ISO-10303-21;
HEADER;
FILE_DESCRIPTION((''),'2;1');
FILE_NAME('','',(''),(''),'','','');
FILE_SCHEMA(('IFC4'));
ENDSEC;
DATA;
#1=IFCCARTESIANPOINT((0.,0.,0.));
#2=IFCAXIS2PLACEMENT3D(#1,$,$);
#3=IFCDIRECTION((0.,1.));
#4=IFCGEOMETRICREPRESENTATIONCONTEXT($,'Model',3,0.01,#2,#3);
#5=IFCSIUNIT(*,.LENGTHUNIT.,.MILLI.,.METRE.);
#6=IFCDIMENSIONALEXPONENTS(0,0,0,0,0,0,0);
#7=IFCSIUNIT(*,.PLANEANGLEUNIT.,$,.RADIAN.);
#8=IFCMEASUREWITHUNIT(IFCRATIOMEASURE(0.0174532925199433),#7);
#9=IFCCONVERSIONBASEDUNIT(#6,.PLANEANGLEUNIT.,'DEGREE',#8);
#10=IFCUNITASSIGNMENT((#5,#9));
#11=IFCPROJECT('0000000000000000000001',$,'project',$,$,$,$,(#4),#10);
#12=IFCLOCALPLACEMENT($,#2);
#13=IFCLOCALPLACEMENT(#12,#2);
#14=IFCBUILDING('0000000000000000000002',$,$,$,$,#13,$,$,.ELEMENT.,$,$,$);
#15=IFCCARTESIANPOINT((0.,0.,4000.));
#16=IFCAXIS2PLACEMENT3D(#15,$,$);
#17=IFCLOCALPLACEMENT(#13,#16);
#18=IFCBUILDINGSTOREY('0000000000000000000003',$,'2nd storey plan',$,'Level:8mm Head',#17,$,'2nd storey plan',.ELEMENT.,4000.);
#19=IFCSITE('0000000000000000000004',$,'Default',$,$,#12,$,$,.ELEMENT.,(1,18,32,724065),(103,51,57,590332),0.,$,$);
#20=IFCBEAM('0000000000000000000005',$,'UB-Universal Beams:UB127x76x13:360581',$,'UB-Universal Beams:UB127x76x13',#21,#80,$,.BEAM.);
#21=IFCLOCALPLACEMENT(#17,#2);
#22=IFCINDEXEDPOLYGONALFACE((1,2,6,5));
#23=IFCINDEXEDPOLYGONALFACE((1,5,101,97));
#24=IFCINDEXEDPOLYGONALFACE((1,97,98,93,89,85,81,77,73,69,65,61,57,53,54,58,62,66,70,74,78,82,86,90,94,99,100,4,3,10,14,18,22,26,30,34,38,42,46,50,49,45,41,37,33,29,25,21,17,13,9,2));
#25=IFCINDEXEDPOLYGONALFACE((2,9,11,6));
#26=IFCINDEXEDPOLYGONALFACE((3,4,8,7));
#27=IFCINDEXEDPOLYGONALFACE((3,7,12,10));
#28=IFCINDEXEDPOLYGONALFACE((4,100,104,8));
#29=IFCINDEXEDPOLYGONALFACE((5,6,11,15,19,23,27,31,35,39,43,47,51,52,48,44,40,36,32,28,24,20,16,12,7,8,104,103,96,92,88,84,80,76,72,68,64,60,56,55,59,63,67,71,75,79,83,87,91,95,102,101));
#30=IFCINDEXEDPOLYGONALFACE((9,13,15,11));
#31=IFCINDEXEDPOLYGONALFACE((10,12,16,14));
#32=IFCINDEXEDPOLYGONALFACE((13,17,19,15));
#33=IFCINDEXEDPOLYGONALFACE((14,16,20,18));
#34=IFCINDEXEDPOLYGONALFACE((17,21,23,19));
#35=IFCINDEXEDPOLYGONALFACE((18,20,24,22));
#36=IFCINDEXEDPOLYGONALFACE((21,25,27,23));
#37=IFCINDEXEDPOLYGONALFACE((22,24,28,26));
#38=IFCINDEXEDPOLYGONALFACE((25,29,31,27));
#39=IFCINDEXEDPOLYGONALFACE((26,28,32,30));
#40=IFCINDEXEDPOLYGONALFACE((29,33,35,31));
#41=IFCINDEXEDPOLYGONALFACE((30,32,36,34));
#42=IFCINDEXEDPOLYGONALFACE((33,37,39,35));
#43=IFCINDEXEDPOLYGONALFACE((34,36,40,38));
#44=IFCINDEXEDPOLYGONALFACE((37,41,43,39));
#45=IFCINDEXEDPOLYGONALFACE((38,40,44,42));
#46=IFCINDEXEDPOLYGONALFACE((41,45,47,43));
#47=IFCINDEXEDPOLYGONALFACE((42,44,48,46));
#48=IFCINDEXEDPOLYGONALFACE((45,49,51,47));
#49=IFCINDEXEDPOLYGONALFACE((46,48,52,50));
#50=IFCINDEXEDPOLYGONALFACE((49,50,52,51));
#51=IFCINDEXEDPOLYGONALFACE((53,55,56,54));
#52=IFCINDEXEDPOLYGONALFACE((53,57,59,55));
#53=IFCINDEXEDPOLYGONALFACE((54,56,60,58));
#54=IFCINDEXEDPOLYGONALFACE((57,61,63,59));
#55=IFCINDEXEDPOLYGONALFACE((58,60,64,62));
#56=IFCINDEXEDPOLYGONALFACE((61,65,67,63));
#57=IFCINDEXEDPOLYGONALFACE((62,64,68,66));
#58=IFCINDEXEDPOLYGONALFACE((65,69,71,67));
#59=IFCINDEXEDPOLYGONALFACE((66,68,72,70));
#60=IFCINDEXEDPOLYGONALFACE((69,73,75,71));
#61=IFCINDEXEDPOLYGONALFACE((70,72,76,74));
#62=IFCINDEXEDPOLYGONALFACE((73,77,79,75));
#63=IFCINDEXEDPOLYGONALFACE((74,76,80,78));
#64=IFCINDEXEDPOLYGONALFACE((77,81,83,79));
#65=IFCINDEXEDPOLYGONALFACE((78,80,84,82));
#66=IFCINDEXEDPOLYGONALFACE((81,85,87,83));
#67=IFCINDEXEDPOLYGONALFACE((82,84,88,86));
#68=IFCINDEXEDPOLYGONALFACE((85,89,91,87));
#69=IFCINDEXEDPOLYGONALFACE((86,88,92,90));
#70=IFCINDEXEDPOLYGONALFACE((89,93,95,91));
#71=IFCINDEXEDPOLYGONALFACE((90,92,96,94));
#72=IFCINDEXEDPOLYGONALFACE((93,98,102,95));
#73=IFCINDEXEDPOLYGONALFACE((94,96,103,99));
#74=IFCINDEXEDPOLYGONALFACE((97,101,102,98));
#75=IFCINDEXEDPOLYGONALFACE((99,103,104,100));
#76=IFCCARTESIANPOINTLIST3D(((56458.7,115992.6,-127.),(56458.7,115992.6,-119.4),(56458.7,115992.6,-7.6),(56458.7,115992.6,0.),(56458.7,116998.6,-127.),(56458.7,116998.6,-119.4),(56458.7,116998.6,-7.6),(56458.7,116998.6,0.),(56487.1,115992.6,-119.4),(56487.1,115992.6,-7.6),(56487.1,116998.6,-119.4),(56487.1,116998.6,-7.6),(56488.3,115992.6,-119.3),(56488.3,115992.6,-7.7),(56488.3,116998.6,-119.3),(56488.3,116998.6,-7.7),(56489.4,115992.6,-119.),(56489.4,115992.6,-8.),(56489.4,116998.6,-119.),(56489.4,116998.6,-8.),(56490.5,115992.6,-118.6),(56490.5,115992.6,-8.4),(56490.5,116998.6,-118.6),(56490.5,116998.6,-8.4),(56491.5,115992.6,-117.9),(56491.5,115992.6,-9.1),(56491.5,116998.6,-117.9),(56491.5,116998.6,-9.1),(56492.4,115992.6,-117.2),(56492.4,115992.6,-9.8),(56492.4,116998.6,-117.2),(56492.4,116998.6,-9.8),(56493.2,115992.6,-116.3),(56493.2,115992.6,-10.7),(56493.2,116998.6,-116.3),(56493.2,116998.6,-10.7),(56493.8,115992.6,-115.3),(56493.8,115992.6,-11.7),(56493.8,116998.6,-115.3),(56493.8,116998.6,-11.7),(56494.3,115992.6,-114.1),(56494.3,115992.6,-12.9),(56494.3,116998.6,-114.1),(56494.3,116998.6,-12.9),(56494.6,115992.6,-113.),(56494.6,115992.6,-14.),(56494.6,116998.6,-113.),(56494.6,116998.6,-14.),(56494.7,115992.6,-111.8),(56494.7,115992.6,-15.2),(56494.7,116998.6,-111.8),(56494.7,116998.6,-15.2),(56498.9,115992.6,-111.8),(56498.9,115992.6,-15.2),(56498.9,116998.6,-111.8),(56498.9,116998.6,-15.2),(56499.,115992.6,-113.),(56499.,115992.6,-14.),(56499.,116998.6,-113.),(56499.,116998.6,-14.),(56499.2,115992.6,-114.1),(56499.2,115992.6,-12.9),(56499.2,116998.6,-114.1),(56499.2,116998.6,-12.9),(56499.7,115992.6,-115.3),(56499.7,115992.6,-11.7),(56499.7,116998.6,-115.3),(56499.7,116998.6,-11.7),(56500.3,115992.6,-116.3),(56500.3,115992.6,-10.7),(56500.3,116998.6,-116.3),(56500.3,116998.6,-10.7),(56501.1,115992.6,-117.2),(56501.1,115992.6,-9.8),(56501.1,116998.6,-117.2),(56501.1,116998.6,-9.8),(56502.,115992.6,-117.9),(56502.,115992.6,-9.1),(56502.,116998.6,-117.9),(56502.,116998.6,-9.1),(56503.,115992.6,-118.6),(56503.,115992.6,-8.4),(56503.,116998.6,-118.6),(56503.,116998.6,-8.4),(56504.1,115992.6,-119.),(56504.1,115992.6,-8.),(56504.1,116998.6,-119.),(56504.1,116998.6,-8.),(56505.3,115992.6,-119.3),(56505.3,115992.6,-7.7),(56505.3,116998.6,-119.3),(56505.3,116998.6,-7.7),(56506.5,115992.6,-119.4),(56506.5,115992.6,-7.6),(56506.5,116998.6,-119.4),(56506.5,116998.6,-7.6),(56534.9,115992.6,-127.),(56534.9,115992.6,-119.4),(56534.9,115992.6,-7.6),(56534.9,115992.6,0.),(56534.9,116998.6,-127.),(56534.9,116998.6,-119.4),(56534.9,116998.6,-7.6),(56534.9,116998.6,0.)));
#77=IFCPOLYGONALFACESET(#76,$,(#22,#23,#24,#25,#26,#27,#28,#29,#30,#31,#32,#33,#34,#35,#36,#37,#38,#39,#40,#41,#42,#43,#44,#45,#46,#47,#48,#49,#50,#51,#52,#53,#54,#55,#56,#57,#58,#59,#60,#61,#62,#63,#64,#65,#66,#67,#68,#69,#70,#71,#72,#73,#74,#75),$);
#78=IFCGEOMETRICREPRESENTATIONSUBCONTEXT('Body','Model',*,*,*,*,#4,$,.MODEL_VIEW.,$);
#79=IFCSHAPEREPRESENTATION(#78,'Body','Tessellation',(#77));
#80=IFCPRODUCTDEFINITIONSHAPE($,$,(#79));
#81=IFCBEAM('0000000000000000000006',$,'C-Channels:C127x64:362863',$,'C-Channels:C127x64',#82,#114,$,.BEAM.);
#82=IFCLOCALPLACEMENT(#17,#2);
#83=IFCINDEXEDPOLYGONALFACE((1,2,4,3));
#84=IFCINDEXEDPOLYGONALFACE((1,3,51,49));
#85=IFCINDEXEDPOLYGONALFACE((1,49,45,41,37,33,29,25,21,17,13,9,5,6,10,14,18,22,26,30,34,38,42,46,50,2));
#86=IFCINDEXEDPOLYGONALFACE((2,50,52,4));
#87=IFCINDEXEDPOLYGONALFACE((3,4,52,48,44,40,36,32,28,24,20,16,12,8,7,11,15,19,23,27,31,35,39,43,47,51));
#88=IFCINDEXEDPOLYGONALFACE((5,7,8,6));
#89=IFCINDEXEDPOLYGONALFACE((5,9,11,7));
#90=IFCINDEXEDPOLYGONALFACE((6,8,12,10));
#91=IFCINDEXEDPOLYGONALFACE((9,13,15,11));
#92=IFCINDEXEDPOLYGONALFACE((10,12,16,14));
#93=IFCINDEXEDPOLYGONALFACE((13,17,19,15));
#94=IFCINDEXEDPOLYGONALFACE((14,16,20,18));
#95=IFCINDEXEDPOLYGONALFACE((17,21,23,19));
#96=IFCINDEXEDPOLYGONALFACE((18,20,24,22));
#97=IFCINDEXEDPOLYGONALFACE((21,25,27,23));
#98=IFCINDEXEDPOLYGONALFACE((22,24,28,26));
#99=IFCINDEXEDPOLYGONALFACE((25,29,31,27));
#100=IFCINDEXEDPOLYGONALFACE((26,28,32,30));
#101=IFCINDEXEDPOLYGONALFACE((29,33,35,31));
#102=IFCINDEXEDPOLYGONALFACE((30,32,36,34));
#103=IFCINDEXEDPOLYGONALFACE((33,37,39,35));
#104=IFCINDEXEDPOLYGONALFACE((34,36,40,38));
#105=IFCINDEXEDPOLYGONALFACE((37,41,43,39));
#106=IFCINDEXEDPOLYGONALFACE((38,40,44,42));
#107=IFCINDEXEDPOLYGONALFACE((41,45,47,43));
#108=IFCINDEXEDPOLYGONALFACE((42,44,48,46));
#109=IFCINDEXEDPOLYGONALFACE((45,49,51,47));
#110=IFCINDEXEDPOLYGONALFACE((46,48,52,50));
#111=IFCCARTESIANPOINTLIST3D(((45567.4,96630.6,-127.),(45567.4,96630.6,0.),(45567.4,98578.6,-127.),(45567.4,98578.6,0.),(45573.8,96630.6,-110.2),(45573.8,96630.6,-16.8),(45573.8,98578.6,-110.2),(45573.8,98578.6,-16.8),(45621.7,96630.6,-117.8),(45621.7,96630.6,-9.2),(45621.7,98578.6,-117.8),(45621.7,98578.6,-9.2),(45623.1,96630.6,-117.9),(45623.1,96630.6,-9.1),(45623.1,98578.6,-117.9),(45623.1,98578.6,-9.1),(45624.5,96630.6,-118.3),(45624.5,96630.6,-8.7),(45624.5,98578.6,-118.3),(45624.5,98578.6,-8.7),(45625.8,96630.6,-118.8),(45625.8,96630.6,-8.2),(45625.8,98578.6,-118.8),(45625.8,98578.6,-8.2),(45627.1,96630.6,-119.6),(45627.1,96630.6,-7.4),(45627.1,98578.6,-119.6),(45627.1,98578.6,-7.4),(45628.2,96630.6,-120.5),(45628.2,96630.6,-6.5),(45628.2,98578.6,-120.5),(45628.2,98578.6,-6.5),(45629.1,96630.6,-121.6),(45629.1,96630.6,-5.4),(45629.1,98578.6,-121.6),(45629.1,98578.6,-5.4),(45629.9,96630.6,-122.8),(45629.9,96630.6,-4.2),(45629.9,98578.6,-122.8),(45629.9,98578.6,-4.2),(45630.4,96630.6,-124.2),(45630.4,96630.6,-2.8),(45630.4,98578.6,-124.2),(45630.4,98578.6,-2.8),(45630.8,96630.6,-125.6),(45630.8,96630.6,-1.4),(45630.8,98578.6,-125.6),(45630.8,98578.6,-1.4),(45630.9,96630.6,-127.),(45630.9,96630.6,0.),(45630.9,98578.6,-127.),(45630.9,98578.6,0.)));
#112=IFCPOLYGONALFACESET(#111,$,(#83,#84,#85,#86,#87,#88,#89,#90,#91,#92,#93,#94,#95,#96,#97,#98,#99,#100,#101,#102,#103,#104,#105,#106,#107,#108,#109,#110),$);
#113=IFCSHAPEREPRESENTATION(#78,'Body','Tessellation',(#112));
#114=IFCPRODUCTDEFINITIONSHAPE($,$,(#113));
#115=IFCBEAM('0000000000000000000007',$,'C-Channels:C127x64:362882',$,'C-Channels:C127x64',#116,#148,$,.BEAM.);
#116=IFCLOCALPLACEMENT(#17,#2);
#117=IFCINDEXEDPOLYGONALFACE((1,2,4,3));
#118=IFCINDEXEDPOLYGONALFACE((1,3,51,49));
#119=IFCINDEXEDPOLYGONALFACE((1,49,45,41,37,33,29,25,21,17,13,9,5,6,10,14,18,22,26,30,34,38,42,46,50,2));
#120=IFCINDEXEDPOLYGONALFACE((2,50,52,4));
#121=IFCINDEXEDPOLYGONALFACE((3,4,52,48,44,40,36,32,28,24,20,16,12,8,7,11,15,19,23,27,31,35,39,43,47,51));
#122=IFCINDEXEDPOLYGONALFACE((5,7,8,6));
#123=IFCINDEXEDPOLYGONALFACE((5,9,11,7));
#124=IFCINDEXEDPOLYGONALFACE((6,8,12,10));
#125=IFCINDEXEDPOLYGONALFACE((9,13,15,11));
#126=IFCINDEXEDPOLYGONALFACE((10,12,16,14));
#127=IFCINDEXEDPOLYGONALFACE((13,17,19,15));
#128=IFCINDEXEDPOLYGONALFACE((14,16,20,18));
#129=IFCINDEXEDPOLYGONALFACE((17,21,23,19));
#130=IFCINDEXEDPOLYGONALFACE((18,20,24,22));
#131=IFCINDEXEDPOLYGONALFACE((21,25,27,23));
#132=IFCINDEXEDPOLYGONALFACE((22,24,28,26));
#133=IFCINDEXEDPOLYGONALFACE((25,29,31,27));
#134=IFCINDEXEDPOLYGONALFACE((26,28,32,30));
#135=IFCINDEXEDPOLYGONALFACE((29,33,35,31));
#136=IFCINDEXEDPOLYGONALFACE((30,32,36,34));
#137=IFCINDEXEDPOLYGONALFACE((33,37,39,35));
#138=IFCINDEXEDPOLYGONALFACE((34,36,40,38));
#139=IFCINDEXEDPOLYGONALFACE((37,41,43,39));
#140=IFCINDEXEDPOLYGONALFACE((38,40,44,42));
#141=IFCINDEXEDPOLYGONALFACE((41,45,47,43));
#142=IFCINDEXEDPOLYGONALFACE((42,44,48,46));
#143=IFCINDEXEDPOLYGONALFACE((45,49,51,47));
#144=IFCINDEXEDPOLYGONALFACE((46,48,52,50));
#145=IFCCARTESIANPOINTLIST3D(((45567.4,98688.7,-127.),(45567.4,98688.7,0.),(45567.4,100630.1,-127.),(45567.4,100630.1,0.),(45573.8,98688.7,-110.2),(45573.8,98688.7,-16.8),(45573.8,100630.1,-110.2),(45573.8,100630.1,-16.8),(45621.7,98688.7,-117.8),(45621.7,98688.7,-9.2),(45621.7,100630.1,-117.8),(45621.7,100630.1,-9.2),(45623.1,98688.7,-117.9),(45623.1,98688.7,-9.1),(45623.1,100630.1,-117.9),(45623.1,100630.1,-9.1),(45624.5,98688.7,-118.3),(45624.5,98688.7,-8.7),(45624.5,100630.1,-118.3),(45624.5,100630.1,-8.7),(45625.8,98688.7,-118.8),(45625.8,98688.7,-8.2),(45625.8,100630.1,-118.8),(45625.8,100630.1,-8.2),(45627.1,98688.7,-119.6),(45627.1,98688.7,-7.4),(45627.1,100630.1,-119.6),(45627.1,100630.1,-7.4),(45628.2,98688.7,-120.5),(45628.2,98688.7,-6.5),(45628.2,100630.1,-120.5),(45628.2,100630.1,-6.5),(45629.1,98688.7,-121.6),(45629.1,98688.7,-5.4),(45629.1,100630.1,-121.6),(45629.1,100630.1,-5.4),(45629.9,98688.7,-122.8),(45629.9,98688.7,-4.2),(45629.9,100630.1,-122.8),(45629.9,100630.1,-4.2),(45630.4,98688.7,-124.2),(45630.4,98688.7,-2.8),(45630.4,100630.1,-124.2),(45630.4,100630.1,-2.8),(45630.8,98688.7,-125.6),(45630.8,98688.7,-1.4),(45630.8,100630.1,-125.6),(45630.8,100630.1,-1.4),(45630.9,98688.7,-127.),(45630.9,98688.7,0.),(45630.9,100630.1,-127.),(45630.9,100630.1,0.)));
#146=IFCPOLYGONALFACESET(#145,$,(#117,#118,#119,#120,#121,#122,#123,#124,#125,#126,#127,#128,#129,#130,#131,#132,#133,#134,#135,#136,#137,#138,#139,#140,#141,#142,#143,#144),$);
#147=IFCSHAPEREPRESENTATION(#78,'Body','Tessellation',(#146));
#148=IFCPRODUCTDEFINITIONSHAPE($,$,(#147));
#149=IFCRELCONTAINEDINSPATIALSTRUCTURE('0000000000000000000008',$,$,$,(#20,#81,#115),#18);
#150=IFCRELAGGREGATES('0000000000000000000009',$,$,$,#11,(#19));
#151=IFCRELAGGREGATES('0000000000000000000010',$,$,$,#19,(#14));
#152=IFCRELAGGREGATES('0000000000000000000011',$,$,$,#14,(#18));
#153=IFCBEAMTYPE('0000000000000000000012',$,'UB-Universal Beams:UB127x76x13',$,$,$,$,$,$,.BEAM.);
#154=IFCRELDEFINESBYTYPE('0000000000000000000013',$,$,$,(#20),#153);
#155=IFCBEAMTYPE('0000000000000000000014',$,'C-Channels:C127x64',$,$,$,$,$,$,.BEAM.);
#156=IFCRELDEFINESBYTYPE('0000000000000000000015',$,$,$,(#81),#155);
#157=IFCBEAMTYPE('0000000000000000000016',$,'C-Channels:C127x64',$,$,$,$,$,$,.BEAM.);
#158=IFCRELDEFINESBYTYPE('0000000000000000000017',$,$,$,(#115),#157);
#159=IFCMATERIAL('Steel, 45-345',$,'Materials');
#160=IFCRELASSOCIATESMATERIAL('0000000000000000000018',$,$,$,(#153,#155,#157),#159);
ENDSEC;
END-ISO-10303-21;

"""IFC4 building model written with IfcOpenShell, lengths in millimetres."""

from ifc_helpers import new_model, entity, si_unit, converted_unit, direction, frame, origin, place, context, subcontext, project, spatial, indexed_curve, outline, extrude, source, transform, mapped, material, type_object, type_shapes, element, save


model = new_model("IFC4")

# Units and contexts
model_context = context("Model", 3, precision=0.01, world=origin(), true_north=direction((0.0, 1.0)))
body_context = subcontext(model_context, "Body", "Model", "MODEL_VIEW")
ifc_project = project(units=[si_unit("LENGTHUNIT", "METRE", prefix="MILLI"), converted_unit("PLANEANGLEUNIT", "DEGREE", entity("IfcRatioMeasure", 0.0174532925199433), si_unit("PLANEANGLEUNIT", "RADIAN"), dimensions=[0, 0, 0, 0, 0, 0, 0])], contexts=[model_context])

# Site, building, storey
site_placement = place(None, origin())
site = spatial("IfcSite", under=ifc_project, at=site_placement, Name="Default", CompositionType="ELEMENT", RefLatitude=(1, 18, 32, 724065), RefLongitude=(103, 51, 57, 590332), RefElevation=0.0)
building_placement = place(site_placement, origin())
building = spatial("IfcBuilding", under=site, at=building_placement, CompositionType="ELEMENT")
storey_placement = place(building_placement, frame((0.0, 0.0, 4000.0)))
storey = spatial("IfcBuildingStorey", under=building, at=storey_placement, Name="2nd storey plan", ObjectType="Level:8mm Head", LongName="2nd storey plan", CompositionType="ELEMENT", Elevation=4000.0)

# Beams
ifc_material_1 = material(Name="Steel, 45-345", Category="Materials")
beam_type_1 = type_object("IfcBeamType", Name="UB-Universal Beams:UB127x76x13", PredefinedType="BEAM", material=ifc_material_1)
shared_shape_1 = source(origin(), body_context, "Body", "SweptSolid", [
    extrude(outline(indexed_curve([(-63.5, -38.1), (-55.9, -38.1), (-55.9, -9.7), (-55.8, -8.5), (-55.5, -7.4), (-55.1, -6.2), (-54.4, -5.2), (-53.7, -4.3), (-52.8, -3.6), (-51.8, -2.9), (-50.6, -2.5), (-49.5, -2.2), (-48.3, -2.1), (48.3, -2.1), (49.5, -2.2), (50.6, -2.5), (51.8, -2.9), (52.8, -3.6), (53.7, -4.3), (54.4, -5.2), (55.1, -6.2), (55.5, -7.4), (55.8, -8.5), (55.9, -9.7), (55.9, -38.1), (63.5, -38.1), (63.5, 38.1), (55.9, 38.1), (55.9, 9.7), (55.8, 8.5), (55.5, 7.4), (55.1, 6.2), (54.4, 5.2), (53.7, 4.3), (52.8, 3.6), (51.8, 2.9), (50.6, 2.5), (49.5, 2.2), (48.3, 2.1), (-48.3, 2.1), (-49.5, 2.2), (-50.6, 2.5), (-51.8, 2.9), (-52.8, 3.6), (-53.7, 4.3), (-54.4, 5.2), (-55.1, 6.2), (-55.5, 7.4), (-55.8, 8.5), (-55.9, 9.7), (-55.9, 38.1), (-63.5, 38.1), (-63.5, -38.1)], self_intersect=False)), frame((-337.5, 0.0, 0.0), z_axis=(1.0, 0.0, 0.0), x_axis=(0.0, 0.0, -1.0)), (0.0, 0.0, 1.0), 1006.0),
])
type_shapes(beam_type_1, [shared_shape_1])
beam_1_placement = place(storey_placement, frame((56496.8, 116330.1, -63.5), z_axis=(0.0, 0.0, 1.0), x_axis=(0.0, 1.0, 0.0)))
element("IfcBeam", 1, at=beam_1_placement, inside=storey, type_object=beam_type_1, Name="UB-Universal Beams:UB127x76x13:360581", ObjectType="UB-Universal Beams:UB127x76x13", PredefinedType="BEAM", context=body_context, shape_type="MappedRepresentation", body=[
    mapped(shared_shape_1, transform((0.0, 0.0, 0.0), scale=1.0)),
])
beam_type_2 = type_object("IfcBeamType", Name="C-Channels:C127x64", PredefinedType="BEAM", material=ifc_material_1)
shared_shape_2 = source(origin(), body_context, "Body", "SweptSolid", [
    extrude(outline(indexed_curve([(-32.5, -63.5), (31.0, -63.5), (31.0, 63.5), (-32.4, 63.5), (-32.3, 62.1), (-32.0, 60.7), (-31.4, 59.3), (-30.7, 58.1), (-29.8, 57.0), (-28.7, 56.1), (-27.4, 55.3), (-26.1, 54.8), (-24.7, 54.4), (-23.2, 54.3), (24.6, 46.7), (24.6, -46.7), (-23.2, -54.3), (-24.7, -54.4), (-26.1, -54.8), (-27.4, -55.3), (-28.7, -56.1), (-29.8, -57.0), (-30.7, -58.1), (-31.4, -59.3), (-32.0, -60.7), (-32.3, -62.1), (-32.5, -63.5)], self_intersect=False)), frame((-974.0, -11.7, 0.0), z_axis=(1.0, 0.0, 0.0), x_axis=(0.0, 1.0, 0.0)), (0.0, 0.0, 1.0), 1948.0),
])
type_shapes(beam_type_2, [shared_shape_2])
beam_2_placement = place(storey_placement, frame((45586.8, 97604.6, -63.5), z_axis=(0.0, 0.0, 1.0), x_axis=(0.0, 1.0, 0.0)))
element("IfcBeam", 2, at=beam_2_placement, inside=storey, type_object=beam_type_2, Name="C-Channels:C127x64:362863", ObjectType="C-Channels:C127x64", PredefinedType="BEAM", context=body_context, shape_type="MappedRepresentation", body=[
    mapped(shared_shape_2, transform((0.0, 0.0, 0.0), scale=1.0)),
])
beam_type_3 = type_object("IfcBeamType", Name="C-Channels:C127x64", PredefinedType="BEAM", material=ifc_material_1)
shared_shape_3 = source(origin(), body_context, "Body", "SweptSolid", [
    extrude(outline(indexed_curve([(-32.5, -63.5), (31.0, -63.5), (31.0, 63.5), (-32.4, 63.5), (-32.3, 62.1), (-32.0, 60.7), (-31.4, 59.3), (-30.7, 58.1), (-29.8, 57.0), (-28.7, 56.1), (-27.4, 55.3), (-26.1, 54.8), (-24.7, 54.4), (-23.2, 54.3), (24.6, 46.7), (24.6, -46.7), (-23.2, -54.3), (-24.7, -54.4), (-26.1, -54.8), (-27.4, -55.3), (-28.7, -56.1), (-29.8, -57.0), (-30.7, -58.1), (-31.4, -59.3), (-32.0, -60.7), (-32.3, -62.1), (-32.5, -63.5)], self_intersect=False)), frame((-965.8, -11.7, 0.0), z_axis=(1.0, 0.0, 0.0), x_axis=(0.0, 1.0, 0.0)), (0.0, 0.0, 1.0), 1941.4),
])
type_shapes(beam_type_3, [shared_shape_3])
beam_3_placement = place(storey_placement, frame((45586.8, 99654.6, -63.5), z_axis=(0.0, 0.0, 1.0), x_axis=(0.0, 1.0, 0.0)))
element("IfcBeam", 3, at=beam_3_placement, inside=storey, type_object=beam_type_3, Name="C-Channels:C127x64:362882", ObjectType="C-Channels:C127x64", PredefinedType="BEAM", context=body_context, shape_type="MappedRepresentation", body=[
    mapped(shared_shape_3, transform((0.0, 0.0, 0.0), scale=1.0)),
])

save(model, "model.ifc")
